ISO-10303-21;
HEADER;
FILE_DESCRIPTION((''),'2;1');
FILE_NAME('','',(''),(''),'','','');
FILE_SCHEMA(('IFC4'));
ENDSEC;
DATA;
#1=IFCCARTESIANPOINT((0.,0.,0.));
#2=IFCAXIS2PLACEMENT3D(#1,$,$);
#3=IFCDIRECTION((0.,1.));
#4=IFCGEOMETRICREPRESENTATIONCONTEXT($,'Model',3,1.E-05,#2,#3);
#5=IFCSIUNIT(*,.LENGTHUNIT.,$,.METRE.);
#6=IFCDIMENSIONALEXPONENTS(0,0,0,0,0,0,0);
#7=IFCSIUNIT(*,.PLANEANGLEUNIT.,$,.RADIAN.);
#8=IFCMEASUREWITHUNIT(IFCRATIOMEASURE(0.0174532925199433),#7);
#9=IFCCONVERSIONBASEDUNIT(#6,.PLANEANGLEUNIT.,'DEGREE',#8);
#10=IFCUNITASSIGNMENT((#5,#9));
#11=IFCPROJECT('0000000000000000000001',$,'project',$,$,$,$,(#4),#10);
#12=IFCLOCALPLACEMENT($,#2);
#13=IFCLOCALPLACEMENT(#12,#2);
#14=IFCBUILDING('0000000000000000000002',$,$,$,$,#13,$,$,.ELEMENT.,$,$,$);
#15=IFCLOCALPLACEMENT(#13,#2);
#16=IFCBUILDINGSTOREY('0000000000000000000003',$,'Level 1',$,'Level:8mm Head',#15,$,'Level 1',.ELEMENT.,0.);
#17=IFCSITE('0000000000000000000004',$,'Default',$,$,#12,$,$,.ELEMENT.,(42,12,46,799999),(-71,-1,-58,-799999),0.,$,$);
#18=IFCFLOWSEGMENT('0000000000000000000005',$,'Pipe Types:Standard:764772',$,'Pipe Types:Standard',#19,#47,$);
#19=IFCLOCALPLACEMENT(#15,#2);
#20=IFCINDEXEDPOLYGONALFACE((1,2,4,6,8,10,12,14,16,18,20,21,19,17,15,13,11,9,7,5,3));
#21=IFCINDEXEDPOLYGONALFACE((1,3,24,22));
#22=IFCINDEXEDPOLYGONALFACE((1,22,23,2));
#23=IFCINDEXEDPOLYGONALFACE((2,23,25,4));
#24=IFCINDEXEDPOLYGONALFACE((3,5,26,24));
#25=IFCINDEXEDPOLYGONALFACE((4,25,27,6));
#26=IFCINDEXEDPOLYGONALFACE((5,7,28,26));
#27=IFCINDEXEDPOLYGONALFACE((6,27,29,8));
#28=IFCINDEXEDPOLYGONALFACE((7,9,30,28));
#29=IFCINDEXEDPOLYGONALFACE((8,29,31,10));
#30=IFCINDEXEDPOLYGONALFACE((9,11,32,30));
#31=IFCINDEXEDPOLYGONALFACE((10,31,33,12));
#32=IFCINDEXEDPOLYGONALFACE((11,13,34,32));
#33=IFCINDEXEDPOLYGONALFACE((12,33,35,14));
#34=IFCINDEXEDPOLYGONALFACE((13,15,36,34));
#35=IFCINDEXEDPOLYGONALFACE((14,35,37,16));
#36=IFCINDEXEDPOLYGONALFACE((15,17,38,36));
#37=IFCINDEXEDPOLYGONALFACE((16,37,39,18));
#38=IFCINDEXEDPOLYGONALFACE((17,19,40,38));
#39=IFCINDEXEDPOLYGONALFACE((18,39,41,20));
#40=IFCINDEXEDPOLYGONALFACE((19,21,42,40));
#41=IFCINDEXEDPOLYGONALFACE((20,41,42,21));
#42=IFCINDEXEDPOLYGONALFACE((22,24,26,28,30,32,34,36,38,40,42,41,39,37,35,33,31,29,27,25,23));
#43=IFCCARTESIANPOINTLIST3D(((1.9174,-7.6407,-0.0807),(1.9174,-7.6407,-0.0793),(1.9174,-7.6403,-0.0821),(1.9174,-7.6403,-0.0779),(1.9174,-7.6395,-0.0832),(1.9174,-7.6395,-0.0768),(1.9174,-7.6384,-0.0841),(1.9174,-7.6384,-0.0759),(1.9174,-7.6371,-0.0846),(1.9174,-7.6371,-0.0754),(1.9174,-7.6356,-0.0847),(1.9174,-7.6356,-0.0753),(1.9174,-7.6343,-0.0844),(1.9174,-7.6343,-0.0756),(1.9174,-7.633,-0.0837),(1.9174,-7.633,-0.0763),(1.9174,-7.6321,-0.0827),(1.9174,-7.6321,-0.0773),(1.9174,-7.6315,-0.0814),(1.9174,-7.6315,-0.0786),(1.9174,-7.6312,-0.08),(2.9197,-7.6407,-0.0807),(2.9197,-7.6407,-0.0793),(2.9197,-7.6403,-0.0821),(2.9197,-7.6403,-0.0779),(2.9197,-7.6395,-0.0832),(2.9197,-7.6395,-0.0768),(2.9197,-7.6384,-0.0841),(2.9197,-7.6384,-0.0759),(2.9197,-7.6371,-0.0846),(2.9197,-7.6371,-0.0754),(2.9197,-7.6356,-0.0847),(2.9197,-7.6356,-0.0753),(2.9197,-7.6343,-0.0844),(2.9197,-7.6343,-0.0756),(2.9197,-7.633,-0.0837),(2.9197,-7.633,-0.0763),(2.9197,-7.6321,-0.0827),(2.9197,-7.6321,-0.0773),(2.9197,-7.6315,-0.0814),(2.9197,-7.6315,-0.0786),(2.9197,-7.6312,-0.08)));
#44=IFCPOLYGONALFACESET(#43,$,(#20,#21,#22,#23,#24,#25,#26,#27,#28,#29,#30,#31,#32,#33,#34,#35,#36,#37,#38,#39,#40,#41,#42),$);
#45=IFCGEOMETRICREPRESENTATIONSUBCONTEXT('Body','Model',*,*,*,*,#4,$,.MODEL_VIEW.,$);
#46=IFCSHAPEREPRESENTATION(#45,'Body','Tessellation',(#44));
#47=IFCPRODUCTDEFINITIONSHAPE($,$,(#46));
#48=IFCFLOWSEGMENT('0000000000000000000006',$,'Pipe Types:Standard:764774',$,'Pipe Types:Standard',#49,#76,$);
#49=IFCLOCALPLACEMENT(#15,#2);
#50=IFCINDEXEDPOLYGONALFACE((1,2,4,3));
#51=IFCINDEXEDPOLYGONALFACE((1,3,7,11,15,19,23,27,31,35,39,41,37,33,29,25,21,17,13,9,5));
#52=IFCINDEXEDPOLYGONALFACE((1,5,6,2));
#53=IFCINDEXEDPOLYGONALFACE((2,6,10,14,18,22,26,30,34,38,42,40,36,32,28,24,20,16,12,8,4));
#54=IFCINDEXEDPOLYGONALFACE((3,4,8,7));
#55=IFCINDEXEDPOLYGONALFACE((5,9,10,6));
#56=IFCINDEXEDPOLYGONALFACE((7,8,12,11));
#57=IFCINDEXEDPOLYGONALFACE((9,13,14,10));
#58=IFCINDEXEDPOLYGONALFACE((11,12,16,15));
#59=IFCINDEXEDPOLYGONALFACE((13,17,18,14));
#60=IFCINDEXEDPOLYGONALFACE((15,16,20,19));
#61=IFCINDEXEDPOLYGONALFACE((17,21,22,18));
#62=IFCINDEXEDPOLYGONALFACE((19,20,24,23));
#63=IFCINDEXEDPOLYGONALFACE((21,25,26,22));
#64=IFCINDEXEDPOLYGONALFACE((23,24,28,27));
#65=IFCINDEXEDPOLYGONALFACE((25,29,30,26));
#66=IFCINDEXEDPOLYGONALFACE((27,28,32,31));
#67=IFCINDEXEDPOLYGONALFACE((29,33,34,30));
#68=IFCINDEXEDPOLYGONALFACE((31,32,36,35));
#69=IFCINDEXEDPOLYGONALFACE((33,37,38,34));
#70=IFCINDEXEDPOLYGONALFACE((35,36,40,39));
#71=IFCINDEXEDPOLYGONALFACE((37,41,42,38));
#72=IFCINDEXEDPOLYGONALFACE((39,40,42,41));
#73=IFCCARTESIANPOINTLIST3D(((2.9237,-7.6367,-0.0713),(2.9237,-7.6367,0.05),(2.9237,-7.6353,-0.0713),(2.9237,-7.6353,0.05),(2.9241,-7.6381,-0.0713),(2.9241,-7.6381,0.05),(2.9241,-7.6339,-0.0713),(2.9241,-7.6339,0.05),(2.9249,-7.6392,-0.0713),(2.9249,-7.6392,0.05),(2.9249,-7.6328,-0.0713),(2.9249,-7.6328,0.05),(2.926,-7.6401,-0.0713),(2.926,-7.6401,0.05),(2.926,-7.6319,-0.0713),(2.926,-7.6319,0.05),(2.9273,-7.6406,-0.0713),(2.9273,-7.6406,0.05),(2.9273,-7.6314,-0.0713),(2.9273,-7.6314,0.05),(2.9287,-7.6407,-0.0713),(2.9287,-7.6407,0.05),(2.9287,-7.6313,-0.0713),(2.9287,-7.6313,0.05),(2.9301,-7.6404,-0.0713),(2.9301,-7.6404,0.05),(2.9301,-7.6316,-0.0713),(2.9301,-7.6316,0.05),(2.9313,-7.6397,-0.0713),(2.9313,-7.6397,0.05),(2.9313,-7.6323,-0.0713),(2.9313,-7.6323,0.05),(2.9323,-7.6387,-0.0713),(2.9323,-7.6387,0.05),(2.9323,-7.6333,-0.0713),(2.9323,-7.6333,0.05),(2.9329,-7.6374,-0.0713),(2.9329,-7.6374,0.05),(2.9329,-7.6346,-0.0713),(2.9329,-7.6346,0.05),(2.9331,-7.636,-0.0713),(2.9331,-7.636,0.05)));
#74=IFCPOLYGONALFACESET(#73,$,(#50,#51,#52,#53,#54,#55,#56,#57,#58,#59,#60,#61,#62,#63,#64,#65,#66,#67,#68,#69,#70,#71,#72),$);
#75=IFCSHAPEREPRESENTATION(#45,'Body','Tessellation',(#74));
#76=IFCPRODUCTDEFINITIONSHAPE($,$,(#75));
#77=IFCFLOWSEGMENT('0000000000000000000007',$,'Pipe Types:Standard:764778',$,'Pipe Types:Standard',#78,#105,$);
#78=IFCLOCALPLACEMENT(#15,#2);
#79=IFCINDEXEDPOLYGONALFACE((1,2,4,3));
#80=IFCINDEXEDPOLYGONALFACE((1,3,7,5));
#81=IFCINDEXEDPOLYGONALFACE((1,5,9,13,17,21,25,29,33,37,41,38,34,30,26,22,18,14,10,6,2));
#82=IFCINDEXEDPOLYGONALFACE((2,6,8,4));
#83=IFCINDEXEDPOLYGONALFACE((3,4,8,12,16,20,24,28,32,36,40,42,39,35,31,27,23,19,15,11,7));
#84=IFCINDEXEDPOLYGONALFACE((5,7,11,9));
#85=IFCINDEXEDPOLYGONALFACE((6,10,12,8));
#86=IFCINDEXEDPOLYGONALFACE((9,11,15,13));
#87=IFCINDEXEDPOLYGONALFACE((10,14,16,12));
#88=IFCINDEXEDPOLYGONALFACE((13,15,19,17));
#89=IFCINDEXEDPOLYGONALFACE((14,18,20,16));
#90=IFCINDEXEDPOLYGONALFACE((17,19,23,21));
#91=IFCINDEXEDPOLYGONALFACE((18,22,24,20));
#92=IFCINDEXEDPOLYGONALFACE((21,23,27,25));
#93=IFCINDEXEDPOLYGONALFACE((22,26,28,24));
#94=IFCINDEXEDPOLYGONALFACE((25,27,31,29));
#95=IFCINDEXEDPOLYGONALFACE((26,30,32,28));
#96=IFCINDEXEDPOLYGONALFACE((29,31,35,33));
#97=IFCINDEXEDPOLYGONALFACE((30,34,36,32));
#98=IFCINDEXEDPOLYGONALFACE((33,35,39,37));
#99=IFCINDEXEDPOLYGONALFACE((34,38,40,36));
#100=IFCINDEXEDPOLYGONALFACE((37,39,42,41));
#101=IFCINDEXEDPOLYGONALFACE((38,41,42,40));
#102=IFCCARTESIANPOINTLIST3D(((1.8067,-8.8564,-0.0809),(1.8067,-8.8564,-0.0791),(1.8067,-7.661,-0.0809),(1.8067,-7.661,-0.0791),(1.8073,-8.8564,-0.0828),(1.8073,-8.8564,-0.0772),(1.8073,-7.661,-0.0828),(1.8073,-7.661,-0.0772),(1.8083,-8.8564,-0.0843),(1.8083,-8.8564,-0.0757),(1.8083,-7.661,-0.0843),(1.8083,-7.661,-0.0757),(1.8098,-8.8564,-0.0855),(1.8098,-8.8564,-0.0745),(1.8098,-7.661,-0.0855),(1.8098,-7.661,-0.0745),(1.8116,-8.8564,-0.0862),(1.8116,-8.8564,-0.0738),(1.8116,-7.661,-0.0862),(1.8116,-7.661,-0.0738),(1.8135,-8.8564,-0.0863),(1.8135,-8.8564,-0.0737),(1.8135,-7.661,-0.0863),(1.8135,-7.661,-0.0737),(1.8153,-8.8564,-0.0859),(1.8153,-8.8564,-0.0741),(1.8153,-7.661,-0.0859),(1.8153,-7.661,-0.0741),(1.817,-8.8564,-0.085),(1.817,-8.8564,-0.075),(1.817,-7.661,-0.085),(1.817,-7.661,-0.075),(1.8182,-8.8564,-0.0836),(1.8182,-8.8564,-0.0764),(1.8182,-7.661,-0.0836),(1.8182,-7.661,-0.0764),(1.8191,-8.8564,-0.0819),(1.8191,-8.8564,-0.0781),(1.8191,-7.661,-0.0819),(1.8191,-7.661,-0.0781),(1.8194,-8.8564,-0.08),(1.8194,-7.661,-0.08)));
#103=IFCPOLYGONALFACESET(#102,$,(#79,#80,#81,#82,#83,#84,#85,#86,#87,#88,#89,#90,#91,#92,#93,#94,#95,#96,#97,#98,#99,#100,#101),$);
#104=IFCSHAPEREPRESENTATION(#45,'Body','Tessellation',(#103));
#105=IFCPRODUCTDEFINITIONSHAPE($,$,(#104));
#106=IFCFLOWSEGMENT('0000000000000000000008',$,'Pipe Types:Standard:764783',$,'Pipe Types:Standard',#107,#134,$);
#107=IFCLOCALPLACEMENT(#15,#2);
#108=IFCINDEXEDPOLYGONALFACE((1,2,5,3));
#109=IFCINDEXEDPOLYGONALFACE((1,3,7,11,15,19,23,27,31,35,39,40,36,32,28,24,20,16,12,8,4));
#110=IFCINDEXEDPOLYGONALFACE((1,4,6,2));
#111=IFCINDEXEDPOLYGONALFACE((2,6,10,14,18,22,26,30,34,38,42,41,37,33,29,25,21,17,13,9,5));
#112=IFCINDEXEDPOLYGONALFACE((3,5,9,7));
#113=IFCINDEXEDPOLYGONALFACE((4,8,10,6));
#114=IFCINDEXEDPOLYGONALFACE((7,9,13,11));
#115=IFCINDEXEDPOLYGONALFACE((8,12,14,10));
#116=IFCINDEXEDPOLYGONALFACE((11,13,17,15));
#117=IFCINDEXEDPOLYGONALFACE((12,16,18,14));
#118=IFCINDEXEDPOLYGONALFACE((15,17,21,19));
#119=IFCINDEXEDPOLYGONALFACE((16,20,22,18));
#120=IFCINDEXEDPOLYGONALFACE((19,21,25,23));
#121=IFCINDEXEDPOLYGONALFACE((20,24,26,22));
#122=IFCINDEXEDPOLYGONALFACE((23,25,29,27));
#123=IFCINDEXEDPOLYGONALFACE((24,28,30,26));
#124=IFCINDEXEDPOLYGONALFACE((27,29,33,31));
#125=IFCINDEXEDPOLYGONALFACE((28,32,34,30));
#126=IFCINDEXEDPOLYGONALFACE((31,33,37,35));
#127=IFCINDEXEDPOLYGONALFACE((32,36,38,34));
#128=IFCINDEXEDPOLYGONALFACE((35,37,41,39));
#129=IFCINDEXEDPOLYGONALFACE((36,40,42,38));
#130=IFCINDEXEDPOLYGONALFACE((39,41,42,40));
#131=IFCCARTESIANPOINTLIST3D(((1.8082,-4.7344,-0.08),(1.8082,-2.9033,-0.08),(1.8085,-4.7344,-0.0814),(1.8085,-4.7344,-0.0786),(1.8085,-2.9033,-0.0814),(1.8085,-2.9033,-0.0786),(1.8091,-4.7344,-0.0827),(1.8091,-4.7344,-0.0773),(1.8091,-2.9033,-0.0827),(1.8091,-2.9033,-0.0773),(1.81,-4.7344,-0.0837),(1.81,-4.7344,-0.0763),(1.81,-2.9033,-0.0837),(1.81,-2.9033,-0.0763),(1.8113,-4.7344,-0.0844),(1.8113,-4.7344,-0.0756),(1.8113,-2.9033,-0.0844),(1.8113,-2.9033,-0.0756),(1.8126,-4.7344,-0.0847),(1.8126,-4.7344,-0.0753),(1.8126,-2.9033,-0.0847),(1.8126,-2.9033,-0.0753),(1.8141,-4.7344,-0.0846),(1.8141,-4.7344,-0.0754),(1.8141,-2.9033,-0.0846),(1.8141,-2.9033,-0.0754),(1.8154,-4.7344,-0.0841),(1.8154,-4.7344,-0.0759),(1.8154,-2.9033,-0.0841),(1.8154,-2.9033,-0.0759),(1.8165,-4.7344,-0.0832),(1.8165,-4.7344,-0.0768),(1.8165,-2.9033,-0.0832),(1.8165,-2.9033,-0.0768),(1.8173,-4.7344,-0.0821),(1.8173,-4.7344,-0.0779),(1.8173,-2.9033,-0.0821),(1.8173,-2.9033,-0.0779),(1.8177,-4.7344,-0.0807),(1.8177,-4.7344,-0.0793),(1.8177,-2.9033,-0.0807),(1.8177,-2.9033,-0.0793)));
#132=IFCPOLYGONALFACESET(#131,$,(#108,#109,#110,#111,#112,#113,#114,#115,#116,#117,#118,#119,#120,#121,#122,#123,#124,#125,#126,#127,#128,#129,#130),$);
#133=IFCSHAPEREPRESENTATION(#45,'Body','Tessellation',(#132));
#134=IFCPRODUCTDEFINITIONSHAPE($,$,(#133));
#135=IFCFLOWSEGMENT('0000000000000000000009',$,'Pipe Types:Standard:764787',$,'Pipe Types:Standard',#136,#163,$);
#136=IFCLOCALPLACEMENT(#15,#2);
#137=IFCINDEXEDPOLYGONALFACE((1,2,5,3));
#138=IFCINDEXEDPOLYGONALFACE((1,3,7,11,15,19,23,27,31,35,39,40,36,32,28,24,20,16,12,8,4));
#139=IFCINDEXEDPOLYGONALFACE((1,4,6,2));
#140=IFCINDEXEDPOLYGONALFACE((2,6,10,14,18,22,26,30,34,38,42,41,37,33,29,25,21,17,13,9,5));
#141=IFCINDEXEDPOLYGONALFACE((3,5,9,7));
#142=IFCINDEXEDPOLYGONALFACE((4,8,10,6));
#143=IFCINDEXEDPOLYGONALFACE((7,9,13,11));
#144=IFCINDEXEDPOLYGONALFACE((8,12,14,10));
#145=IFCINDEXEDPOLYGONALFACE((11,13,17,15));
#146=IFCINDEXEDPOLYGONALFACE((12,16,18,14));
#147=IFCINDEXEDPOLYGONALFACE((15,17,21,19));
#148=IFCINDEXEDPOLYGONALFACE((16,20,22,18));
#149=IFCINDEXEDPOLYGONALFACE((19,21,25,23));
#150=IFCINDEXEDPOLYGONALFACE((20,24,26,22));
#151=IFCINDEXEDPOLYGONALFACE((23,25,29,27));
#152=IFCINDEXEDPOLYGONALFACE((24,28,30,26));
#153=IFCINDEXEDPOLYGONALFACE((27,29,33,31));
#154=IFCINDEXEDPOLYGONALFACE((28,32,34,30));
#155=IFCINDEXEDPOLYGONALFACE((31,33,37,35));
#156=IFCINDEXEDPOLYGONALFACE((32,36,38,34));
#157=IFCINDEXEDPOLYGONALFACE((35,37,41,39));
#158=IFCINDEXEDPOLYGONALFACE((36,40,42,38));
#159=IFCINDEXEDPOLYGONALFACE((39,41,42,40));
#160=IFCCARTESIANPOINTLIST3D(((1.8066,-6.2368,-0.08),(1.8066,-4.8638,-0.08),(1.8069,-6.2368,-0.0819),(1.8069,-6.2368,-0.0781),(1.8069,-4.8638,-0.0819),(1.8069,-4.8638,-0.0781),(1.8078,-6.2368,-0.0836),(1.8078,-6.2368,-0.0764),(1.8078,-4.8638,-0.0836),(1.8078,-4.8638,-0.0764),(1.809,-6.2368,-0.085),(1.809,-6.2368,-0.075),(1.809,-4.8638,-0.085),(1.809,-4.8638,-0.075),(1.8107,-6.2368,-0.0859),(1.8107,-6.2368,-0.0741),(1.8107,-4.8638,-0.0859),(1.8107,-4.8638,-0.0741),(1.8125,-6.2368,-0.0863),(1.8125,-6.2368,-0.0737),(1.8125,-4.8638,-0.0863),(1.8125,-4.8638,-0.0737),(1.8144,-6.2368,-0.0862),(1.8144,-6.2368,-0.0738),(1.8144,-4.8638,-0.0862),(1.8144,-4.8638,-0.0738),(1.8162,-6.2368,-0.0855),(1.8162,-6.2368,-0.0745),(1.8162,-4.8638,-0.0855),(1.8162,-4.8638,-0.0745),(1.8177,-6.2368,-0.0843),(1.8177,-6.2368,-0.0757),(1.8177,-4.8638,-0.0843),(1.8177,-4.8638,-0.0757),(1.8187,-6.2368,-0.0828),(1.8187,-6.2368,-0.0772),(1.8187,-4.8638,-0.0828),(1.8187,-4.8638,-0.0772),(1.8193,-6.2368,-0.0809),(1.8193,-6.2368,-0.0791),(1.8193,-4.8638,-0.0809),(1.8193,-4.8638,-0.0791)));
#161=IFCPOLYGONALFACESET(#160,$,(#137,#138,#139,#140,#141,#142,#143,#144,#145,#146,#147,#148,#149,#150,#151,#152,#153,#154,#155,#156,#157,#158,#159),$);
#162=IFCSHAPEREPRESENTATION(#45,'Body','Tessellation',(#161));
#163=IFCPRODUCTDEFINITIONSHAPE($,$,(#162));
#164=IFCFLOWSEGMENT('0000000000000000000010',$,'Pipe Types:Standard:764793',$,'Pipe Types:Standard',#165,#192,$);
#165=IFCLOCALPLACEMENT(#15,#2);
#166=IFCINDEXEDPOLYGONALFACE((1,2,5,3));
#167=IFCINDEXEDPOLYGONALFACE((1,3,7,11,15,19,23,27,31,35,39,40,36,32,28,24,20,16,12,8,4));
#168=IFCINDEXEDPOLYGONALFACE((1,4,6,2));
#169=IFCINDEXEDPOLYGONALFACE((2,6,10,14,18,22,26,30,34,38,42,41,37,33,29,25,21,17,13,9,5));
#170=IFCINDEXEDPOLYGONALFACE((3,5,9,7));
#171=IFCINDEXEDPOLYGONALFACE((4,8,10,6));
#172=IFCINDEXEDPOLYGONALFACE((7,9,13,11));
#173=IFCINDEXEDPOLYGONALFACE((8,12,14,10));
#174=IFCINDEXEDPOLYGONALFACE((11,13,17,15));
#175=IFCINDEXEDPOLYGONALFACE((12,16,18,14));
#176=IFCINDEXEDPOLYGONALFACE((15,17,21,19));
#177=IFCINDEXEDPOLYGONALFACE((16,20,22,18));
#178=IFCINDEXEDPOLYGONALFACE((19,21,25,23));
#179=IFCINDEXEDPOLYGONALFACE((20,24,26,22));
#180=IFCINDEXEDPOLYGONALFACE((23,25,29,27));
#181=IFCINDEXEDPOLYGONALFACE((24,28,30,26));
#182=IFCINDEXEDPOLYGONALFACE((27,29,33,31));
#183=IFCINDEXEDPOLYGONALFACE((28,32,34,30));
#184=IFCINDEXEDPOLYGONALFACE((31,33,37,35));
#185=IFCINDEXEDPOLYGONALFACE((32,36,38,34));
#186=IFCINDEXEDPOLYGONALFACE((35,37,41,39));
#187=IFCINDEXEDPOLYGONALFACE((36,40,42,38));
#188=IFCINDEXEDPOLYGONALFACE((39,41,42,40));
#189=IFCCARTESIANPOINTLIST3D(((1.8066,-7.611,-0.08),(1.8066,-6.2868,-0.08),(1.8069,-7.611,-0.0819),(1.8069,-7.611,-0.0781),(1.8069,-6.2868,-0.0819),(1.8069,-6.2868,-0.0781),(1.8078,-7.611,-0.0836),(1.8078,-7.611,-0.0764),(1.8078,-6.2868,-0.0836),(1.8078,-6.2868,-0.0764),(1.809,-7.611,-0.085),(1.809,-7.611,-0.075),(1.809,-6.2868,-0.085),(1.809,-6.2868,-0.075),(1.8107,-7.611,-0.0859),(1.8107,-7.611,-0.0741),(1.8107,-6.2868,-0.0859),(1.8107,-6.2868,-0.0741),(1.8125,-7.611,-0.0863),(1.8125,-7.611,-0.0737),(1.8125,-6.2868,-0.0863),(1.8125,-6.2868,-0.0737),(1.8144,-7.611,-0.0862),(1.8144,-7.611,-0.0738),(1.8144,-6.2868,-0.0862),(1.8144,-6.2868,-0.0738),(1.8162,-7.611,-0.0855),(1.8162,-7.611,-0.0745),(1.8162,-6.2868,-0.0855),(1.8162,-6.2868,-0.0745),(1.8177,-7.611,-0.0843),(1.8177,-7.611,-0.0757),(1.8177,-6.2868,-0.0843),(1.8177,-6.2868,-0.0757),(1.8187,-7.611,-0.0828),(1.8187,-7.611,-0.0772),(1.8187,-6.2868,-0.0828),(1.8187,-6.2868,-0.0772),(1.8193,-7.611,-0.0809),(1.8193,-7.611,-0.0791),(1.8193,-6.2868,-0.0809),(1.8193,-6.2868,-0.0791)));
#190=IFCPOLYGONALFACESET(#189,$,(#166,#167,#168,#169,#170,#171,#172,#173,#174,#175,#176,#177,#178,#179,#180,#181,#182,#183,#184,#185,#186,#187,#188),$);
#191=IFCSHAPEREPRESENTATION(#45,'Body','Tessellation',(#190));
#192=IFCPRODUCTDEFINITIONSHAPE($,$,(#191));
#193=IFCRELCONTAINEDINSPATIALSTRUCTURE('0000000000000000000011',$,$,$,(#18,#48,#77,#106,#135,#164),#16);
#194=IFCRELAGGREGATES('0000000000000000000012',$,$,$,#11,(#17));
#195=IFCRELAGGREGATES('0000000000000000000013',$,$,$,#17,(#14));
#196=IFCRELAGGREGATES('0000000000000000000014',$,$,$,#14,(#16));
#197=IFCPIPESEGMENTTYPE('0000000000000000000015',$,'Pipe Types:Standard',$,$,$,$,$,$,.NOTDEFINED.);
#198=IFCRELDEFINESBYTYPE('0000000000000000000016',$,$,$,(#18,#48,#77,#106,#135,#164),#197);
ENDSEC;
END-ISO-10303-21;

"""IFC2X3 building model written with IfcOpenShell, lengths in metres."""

from ifc_helpers import new_model, entity, si_unit, converted_unit, direction, frame, frame_2d, origin, origin_2d_with_axis, place, context, subcontext, project, spatial, circle, extrude, type_object, element, save


model = new_model("IFC2X3")

# Units and contexts
model_context = context("Model", 3, precision=1e-05, world=origin(), true_north=direction((0.0, 1.0)))
body_context = subcontext(model_context, "Body", "Model", "MODEL_VIEW")
ifc_project = project(units=[si_unit("LENGTHUNIT", "METRE"), converted_unit("PLANEANGLEUNIT", "DEGREE", entity("IfcRatioMeasure", 0.0174532925199433), si_unit("PLANEANGLEUNIT", "RADIAN"), dimensions=[0, 0, 0, 0, 0, 0, 0])], contexts=[model_context])

# Site, building, storey
site_placement = place(None, origin())
site = spatial("IfcSite", under=ifc_project, at=site_placement, Name="Default", CompositionType="ELEMENT", RefLatitude=(42, 12, 46, 799999), RefLongitude=(-71, -1, -58, -799999), RefElevation=0.0)
building_placement = place(site_placement, origin())
building = spatial("IfcBuilding", under=site, at=building_placement, CompositionType="ELEMENT")
storey_placement = place(building_placement, origin())
storey = spatial("IfcBuildingStorey", under=building, at=storey_placement, Name="Level 1", ObjectType="Level:8mm Head", LongName="Level 1", CompositionType="ELEMENT", Elevation=0.0)

# Flow segments
pipe_segment_type = type_object("IfcPipeSegmentType", Name="Pipe Types:Standard", PredefinedType="NOTDEFINED")
flow_segment_1_placement = place(storey_placement, origin())
element("IfcFlowSegment", 1, at=flow_segment_1_placement, inside=storey, type_object=pipe_segment_type, Name="Pipe Types:Standard:764772", ObjectType="Pipe Types:Standard", context=body_context, shape_type="SweptSolid", body=[
    extrude(circle(Radius=0.0048, at=frame_2d((0.0, 0.0), x_axis=(1.0, 0.0))), frame((1.9174, -7.636, -0.08), z_axis=(1.0, 0.0, 0.0), x_axis=(0.0, 1.0, 0.0)), (0.0, 0.0, 1.0), 1.0022),
])
flow_segment_2_placement = place(storey_placement, origin())
element("IfcFlowSegment", 2, at=flow_segment_2_placement, inside=storey, type_object=pipe_segment_type, Name="Pipe Types:Standard:764774", ObjectType="Pipe Types:Standard", context=body_context, shape_type="SweptSolid", body=[
    extrude(circle(Radius=0.0048, at=origin_2d_with_axis()), frame((2.9284, -7.636, -0.0713)), (0.0, 0.0, 1.0), 0.1213),
])
flow_segment_3_placement = place(storey_placement, origin())
element("IfcFlowSegment", 3, at=flow_segment_3_placement, inside=storey, type_object=pipe_segment_type, Name="Pipe Types:Standard:764778", ObjectType="Pipe Types:Standard", context=body_context, shape_type="SweptSolid", body=[
    extrude(circle(Radius=0.0063, at=origin_2d_with_axis()), frame((1.813, -8.8564, -0.08), z_axis=(0.0, 1.0, 0.0), x_axis=(1.0, 0.0, 0.0)), (0.0, 0.0, 1.0), 1.1954),
])
flow_segment_4_placement = place(storey_placement, origin())
element("IfcFlowSegment", 4, at=flow_segment_4_placement, inside=storey, type_object=pipe_segment_type, Name="Pipe Types:Standard:764783", ObjectType="Pipe Types:Standard", context=body_context, shape_type="SweptSolid", body=[
    extrude(circle(Radius=0.0048, at=frame_2d((0.0, 0.0), x_axis=(1.0, 0.0))), frame((1.813, -4.7344, -0.08), z_axis=(0.0, 1.0, 0.0), x_axis=(-1.0, 0.0, 0.0)), (0.0, 0.0, 1.0), 1.8311),
])
flow_segment_5_placement = place(storey_placement, origin())
element("IfcFlowSegment", 5, at=flow_segment_5_placement, inside=storey, type_object=pipe_segment_type, Name="Pipe Types:Standard:764787", ObjectType="Pipe Types:Standard", context=body_context, shape_type="SweptSolid", body=[
    extrude(circle(Radius=0.0063, at=frame_2d((0.0, 0.0), x_axis=(1.0, 0.0))), frame((1.813, -6.2368, -0.08), z_axis=(0.0, 1.0, 0.0), x_axis=(-1.0, 0.0, 0.0)), (0.0, 0.0, 1.0), 1.373),
])
flow_segment_6_placement = place(storey_placement, origin())
element("IfcFlowSegment", 6, at=flow_segment_6_placement, inside=storey, type_object=pipe_segment_type, Name="Pipe Types:Standard:764793", ObjectType="Pipe Types:Standard", context=body_context, shape_type="SweptSolid", body=[
    extrude(circle(Radius=0.0063, at=frame_2d((0.0, 0.0), x_axis=(1.0, 0.0))), frame((1.813, -7.611, -0.08), z_axis=(0.0, 1.0, 0.0), x_axis=(-1.0, 0.0, 0.0)), (0.0, 0.0, 1.0), 1.3242),
])

save(model, "model.ifc")
